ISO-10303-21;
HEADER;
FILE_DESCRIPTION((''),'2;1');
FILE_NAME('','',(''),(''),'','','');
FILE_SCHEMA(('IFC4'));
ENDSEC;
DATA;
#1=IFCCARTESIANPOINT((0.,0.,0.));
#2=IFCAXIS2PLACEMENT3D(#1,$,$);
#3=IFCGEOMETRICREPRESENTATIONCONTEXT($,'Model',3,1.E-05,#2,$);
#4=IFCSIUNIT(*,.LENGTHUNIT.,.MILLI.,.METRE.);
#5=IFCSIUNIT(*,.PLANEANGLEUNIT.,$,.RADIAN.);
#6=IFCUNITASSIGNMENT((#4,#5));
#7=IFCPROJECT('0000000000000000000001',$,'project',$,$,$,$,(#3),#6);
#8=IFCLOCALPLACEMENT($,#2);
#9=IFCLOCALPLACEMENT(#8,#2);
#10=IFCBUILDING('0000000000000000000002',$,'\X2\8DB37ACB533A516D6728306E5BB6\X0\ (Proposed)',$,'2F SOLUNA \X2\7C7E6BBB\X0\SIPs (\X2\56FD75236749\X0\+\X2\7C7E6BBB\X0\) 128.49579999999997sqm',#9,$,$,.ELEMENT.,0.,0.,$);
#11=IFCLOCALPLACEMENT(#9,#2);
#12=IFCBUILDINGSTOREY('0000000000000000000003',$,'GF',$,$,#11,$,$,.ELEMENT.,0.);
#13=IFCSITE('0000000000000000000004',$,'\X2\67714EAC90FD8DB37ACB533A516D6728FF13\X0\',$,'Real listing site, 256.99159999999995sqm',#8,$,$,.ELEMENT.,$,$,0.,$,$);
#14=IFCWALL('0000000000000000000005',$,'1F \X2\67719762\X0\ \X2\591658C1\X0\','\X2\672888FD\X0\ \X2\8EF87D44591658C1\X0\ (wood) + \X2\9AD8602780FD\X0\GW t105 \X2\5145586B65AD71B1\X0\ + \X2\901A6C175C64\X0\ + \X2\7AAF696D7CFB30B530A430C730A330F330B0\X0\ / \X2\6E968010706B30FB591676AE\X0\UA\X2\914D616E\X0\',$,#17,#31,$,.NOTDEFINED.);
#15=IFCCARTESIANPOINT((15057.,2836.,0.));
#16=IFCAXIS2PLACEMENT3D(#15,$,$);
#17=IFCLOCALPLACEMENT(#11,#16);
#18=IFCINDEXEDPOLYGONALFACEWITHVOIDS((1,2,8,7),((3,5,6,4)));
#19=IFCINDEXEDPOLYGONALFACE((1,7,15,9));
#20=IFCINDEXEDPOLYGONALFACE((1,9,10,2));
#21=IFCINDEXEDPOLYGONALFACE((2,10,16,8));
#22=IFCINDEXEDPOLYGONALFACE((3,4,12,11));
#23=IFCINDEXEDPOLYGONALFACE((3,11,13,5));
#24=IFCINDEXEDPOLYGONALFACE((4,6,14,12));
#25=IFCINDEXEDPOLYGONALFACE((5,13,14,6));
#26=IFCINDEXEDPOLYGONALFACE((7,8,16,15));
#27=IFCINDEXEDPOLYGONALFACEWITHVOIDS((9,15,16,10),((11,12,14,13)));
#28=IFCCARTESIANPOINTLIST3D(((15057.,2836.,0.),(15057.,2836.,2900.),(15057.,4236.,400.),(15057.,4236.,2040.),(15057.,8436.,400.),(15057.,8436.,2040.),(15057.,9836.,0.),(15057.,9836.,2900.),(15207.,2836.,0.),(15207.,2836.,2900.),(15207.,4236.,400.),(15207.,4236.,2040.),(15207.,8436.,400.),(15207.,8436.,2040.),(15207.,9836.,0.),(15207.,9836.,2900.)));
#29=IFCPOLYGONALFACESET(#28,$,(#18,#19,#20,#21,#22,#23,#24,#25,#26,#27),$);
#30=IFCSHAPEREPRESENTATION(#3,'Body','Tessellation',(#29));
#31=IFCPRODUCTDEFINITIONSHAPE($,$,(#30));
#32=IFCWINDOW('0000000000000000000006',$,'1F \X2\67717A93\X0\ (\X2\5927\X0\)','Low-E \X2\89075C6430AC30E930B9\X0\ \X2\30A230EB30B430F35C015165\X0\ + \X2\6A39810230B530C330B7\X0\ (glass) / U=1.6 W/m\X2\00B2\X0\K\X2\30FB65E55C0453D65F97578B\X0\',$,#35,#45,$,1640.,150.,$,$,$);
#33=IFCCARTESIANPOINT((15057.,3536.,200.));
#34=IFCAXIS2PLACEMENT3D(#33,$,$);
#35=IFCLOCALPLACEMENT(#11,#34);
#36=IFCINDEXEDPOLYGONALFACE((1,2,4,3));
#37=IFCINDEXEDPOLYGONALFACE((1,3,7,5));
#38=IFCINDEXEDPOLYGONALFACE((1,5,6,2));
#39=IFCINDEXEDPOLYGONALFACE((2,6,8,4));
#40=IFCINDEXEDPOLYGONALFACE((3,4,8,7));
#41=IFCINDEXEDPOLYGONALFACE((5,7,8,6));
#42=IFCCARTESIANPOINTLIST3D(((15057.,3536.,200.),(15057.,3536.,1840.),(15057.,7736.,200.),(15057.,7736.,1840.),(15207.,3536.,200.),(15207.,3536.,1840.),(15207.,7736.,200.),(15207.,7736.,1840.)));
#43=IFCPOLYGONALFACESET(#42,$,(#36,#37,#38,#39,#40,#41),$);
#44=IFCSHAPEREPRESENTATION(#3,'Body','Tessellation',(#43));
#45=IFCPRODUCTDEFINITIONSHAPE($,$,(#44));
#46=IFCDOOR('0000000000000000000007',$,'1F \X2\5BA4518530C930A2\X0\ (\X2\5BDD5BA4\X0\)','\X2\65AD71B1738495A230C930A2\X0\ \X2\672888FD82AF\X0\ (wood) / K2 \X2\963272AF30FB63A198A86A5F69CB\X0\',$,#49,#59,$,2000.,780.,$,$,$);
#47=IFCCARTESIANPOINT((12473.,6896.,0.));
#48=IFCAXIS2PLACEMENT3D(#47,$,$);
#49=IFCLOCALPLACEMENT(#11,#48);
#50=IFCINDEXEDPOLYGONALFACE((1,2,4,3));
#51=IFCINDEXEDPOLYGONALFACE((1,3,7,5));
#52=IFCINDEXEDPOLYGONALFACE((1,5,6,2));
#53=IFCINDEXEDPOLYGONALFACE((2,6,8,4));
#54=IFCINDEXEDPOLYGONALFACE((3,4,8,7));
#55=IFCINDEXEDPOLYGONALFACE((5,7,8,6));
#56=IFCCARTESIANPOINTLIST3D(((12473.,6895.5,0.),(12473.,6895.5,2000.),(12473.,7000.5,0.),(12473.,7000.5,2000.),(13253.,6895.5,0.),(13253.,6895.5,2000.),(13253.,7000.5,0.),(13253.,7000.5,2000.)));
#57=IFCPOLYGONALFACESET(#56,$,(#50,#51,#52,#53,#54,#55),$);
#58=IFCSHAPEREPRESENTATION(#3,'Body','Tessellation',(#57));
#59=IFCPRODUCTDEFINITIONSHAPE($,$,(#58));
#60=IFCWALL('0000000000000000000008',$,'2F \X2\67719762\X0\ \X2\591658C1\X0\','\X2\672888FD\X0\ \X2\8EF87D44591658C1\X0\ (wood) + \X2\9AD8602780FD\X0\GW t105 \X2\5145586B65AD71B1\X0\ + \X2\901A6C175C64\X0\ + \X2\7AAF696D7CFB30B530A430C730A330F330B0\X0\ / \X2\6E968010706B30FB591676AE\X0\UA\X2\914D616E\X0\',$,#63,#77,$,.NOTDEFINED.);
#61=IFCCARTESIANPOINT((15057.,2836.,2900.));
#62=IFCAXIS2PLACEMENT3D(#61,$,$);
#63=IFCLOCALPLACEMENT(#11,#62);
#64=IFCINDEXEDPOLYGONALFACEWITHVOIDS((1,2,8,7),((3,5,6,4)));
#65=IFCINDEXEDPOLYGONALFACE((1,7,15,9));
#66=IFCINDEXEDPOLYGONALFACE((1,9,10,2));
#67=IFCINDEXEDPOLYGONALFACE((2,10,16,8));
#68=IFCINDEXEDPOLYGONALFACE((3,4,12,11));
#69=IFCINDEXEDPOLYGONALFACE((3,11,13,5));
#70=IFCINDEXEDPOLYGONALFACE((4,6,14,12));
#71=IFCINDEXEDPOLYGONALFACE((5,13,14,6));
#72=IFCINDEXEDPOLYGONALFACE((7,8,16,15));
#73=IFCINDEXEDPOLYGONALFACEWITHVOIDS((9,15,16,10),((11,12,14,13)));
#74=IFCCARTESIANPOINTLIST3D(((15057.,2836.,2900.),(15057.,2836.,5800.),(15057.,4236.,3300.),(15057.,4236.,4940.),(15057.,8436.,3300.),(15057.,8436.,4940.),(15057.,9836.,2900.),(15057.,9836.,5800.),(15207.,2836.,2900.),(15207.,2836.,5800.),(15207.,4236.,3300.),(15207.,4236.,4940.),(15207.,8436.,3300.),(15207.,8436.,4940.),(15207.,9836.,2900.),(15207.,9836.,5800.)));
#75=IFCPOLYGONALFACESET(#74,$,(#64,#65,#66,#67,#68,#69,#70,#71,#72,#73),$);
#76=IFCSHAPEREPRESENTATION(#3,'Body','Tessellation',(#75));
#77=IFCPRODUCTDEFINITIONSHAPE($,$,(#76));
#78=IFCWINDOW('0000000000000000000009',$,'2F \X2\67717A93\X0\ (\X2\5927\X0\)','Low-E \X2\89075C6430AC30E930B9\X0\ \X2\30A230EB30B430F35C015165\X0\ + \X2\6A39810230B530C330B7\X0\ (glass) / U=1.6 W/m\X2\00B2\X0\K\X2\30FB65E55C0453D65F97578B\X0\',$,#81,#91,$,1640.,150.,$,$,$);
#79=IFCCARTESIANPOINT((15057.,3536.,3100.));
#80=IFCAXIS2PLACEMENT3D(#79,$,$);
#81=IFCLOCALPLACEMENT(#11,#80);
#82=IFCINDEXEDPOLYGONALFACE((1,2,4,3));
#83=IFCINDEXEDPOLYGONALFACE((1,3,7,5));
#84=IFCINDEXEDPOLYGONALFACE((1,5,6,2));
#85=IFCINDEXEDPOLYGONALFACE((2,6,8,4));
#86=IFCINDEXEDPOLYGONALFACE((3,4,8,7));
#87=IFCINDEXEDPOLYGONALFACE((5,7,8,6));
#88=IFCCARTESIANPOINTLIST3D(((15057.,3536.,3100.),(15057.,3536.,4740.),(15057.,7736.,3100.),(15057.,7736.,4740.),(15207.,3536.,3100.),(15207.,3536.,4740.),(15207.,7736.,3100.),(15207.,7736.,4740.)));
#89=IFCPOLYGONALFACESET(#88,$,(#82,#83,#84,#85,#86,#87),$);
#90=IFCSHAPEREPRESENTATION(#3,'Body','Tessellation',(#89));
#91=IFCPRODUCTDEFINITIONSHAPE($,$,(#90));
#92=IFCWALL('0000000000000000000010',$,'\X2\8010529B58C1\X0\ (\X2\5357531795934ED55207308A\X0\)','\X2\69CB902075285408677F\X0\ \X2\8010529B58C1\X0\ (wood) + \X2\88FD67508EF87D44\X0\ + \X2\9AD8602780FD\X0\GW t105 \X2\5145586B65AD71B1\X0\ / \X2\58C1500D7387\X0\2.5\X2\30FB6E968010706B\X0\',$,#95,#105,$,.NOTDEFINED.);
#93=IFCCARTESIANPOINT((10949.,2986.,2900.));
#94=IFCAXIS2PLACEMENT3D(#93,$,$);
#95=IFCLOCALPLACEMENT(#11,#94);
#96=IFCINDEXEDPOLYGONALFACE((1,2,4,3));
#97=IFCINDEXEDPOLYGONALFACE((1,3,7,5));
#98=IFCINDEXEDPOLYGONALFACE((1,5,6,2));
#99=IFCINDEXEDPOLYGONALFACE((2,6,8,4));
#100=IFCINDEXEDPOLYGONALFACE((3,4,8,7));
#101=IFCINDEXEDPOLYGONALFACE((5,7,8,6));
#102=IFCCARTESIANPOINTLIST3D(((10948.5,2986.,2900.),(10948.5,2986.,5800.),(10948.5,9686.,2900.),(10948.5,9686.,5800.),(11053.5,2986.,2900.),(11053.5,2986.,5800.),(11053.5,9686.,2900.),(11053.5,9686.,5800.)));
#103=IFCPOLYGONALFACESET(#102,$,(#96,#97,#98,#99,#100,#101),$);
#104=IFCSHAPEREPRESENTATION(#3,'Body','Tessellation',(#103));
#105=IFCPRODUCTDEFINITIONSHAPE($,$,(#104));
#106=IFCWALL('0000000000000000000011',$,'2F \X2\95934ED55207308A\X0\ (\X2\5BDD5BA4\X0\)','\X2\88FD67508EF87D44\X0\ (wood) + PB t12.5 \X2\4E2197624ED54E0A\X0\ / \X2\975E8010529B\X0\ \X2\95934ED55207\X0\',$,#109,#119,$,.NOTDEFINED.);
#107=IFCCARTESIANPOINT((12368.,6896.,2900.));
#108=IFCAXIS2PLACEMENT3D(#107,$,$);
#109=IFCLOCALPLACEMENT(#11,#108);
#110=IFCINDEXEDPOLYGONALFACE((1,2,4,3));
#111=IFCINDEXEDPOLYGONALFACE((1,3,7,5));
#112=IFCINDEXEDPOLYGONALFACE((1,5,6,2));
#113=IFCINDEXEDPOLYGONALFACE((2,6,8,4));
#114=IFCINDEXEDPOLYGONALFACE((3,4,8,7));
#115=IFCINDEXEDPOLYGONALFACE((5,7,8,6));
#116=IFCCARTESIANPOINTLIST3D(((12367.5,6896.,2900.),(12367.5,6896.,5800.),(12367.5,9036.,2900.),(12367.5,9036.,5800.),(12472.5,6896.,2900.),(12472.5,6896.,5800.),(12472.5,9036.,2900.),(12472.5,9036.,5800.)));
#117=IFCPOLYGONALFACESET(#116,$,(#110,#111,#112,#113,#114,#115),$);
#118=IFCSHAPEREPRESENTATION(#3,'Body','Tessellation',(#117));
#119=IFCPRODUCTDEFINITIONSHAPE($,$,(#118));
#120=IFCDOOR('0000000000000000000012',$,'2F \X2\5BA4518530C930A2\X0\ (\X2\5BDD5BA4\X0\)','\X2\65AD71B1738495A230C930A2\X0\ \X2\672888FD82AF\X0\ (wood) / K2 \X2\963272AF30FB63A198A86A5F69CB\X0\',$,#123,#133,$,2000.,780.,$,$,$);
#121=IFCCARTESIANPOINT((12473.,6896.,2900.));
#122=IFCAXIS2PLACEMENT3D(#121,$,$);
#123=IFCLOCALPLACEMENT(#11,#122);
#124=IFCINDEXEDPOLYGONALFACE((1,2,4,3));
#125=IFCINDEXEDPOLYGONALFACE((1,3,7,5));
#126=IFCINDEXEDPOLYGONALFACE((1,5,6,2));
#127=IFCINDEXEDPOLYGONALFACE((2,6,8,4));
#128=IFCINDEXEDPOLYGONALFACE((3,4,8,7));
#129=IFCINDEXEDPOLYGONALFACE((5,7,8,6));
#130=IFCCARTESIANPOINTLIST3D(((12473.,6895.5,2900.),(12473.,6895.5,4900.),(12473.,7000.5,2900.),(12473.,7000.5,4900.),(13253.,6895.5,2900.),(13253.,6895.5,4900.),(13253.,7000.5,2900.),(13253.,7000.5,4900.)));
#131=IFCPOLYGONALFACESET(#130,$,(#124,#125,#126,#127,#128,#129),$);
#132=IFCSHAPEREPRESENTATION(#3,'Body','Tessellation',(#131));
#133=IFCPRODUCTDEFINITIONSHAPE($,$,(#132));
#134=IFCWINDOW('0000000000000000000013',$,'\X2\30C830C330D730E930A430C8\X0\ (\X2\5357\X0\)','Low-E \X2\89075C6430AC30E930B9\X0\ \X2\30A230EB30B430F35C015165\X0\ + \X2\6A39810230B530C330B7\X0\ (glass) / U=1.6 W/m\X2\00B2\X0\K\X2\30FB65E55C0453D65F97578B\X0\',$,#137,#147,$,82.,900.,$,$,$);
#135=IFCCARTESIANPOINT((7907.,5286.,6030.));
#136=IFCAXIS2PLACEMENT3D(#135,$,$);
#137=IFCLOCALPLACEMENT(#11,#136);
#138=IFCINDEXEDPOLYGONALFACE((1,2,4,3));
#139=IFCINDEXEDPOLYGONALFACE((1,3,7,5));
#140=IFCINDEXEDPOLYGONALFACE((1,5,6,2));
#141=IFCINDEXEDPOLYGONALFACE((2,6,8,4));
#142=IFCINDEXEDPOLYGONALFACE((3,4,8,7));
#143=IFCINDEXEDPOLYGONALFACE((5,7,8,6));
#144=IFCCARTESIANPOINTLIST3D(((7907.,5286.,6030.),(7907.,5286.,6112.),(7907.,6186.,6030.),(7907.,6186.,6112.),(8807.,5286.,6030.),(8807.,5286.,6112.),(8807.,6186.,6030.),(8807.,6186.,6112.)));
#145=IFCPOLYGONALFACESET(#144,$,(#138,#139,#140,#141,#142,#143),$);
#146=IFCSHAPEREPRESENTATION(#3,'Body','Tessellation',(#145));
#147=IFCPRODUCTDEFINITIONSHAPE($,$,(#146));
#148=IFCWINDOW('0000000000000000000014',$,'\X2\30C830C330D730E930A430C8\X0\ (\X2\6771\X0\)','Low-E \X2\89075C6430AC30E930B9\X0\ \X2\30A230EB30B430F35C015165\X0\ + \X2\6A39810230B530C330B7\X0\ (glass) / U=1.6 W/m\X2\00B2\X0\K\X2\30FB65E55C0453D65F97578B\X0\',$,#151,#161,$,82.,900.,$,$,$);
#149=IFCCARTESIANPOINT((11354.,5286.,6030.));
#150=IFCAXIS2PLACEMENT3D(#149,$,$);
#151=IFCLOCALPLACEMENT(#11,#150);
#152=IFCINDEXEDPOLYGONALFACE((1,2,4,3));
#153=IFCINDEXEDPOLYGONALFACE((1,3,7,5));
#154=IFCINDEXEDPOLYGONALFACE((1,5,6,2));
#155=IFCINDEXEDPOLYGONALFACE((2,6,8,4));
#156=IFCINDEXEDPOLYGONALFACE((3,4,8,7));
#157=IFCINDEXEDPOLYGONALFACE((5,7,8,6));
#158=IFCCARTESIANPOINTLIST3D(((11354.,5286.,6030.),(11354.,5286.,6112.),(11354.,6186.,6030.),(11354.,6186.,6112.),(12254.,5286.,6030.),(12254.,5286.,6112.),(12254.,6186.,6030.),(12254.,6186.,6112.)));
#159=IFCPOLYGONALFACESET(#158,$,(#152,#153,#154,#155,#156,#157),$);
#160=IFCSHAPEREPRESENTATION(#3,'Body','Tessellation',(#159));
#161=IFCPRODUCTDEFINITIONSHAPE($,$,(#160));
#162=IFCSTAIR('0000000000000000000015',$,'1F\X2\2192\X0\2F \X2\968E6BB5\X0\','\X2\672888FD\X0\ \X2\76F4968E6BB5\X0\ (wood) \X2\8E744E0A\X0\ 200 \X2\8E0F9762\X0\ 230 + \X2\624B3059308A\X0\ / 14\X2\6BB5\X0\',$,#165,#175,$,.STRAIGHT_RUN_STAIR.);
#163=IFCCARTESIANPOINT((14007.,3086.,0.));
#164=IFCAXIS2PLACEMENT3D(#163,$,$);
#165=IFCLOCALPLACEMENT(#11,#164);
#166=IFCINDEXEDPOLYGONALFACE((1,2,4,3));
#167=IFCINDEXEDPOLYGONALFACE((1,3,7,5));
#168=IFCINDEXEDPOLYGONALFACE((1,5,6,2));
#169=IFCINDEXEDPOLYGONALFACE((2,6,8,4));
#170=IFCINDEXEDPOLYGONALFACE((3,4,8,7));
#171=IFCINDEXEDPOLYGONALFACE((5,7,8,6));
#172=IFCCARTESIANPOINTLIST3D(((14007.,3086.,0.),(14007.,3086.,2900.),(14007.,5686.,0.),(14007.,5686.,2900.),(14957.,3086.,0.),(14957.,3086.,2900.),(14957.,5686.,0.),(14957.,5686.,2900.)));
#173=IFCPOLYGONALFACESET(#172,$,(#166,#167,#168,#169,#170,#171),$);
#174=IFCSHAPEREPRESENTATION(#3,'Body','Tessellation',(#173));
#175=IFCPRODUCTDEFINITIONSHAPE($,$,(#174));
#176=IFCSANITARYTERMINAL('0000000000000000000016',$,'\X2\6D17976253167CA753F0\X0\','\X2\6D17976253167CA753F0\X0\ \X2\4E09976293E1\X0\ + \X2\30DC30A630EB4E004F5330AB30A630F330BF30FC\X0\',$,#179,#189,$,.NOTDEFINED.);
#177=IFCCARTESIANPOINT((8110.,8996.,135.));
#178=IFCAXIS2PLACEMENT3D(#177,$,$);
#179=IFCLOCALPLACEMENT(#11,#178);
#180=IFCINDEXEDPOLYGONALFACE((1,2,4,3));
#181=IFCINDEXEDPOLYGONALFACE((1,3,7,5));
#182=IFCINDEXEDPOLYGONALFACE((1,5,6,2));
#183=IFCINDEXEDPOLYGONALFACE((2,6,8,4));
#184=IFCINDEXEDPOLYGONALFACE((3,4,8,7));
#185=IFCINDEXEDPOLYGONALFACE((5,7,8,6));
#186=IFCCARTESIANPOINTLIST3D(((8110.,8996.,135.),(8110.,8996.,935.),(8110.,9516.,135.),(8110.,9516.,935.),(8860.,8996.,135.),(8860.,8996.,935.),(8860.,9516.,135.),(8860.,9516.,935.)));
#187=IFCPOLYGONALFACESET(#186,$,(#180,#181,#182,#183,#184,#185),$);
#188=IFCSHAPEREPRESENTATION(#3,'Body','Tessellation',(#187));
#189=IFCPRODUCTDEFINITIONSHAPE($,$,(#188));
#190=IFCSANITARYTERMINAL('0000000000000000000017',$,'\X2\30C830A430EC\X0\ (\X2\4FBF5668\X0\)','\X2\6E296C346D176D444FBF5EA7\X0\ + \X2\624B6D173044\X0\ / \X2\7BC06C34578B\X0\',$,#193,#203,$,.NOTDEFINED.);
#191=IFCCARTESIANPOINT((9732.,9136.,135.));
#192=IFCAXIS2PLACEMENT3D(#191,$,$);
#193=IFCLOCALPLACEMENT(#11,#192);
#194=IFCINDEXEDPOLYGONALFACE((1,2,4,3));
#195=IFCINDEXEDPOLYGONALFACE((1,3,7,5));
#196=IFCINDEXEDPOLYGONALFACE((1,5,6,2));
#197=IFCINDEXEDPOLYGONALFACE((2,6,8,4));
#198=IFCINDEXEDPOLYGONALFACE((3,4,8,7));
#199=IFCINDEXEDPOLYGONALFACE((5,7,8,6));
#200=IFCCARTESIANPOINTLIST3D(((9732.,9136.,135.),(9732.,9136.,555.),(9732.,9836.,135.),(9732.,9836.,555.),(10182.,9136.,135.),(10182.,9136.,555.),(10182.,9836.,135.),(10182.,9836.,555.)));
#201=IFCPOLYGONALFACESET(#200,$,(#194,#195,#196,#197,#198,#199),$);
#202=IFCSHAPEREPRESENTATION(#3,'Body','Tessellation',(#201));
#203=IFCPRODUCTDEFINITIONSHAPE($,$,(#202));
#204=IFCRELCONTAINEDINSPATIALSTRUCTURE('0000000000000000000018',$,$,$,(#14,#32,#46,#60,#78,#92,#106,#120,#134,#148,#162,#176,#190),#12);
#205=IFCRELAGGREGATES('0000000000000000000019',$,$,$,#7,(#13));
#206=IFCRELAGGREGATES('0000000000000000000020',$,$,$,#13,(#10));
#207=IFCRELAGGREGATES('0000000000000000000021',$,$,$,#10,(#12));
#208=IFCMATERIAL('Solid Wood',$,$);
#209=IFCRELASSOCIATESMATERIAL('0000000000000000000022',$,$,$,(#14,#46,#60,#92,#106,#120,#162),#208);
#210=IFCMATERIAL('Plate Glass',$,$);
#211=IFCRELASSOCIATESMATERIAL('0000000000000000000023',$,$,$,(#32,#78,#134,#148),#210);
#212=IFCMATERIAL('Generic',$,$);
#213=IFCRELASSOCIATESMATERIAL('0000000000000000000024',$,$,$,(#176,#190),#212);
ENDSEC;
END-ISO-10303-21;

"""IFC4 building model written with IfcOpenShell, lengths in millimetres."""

from ifc_helpers import new_model, si_unit, frame, frame_2d, origin, place, context, project, spatial, rectangle, extrude, material, element, fill, save


model = new_model("IFC4")

# Units and contexts
model_context = context("Model", 3, precision=1e-05, world=origin())
ifc_project = project(units=[si_unit("LENGTHUNIT", "METRE", prefix="MILLI"), si_unit("PLANEANGLEUNIT", "RADIAN")], contexts=[model_context])

# Site, building, storey
site_placement = place(None, origin())
site = spatial("IfcSite", under=ifc_project, at=site_placement, Name="東京都足立区六木３", ObjectType="Real listing site, 256.99159999999995sqm", CompositionType="ELEMENT", RefElevation=0.0)
building_placement = place(site_placement, origin())
building = spatial("IfcBuilding", under=site, at=building_placement, Name="足立区六木の家 (Proposed)", ObjectType="2F SOLUNA 籾殻SIPs (国産杉+籾殻) 128.49579999999997sqm", CompositionType="ELEMENT", ElevationOfRefHeight=0.0, ElevationOfTerrain=0.0)
storey_placement = place(building_placement, origin())
storey = spatial("IfcBuildingStorey", under=building, at=storey_placement, Name="GF", CompositionType="ELEMENT", Elevation=0.0)

# Wall, opening, window
ifc_material_1 = material(Name="Solid Wood")
wall_1_placement = place(storey_placement, frame((15057.0, 2836.0, 0.0)))
wall_1 = element("IfcWall", 1, at=wall_1_placement, inside=storey, material=ifc_material_1, Name="1F 東面 外壁", Description="木製 軸組外壁 (wood) + 高性能GW t105 充填断熱 + 通気層 + 窯業系サイディング / 準耐火・外皮UA配慮", PredefinedType="NOTDEFINED", context=model_context, shape_type="SweptSolid", body=[
    extrude(rectangle(XDim=150.0, YDim=7000.0, at=frame_2d((75.0, 3500.0))), frame((15057.0, 2836.0, 0.0)), (0.0, 0.0, 1.0), 2900.0),
])
opening_1_placement = place(storey_placement, frame((15057.0, 3536.0, 200.0)))
opening_1 = element("IfcOpeningElement", 2, at=opening_1_placement, cuts=wall_1, PredefinedType="NOTDEFINED", context=model_context, shape_type="SweptSolid", body=[
    extrude(rectangle(XDim=150.0, YDim=4200.0, at=frame_2d((75.0, 2100.0))), frame((15057.0, 3536.0, 200.0)), (0.0, 0.0, 1.0), 1640.0),
])
ifc_material_2 = material(Name="Plate Glass")
window_1_placement = place(storey_placement, frame((15057.0, 3536.0, 200.0)))
window_1 = element("IfcWindow", 3, at=window_1_placement, inside=storey, material=ifc_material_2, Name="1F 東窓 (大)", Description="Low-E 複層ガラス アルゴン封入 + 樹脂サッシ (glass) / U=1.6 W/m²K・日射取得型", OverallHeight=1640.0, OverallWidth=150.0, context=model_context, shape_type="SweptSolid", body=[
    extrude(rectangle(XDim=150.0, YDim=4200.0, at=frame_2d((75.0, 2100.0))), frame((15057.0, 3536.0, 200.0)), (0.0, 0.0, 1.0), 1640.0),
])
fill(opening_1, window_1)

# Door
door_1_placement = place(storey_placement, frame((12473.0, 6896.0, 0.0)))
element("IfcDoor", 4, at=door_1_placement, inside=storey, material=ifc_material_1, Name="1F 室内ドア (寝室)", Description="断熱玄関ドア 木製芯 (wood) / K2 防犯・採風機構", OverallHeight=2000.0, OverallWidth=780.0, context=model_context, shape_type="SweptSolid", body=[
    extrude(rectangle(XDim=780.0, YDim=105.0, at=frame_2d((390.0, 52.0))), frame((12473.0, 6896.0, 0.0)), (0.0, 0.0, 1.0), 2000.0),
])

# Wall, opening, window
wall_2_placement = place(storey_placement, frame((15057.0, 2836.0, 2900.0)))
wall_2 = element("IfcWall", 5, at=wall_2_placement, inside=storey, material=ifc_material_1, Name="2F 東面 外壁", Description="木製 軸組外壁 (wood) + 高性能GW t105 充填断熱 + 通気層 + 窯業系サイディング / 準耐火・外皮UA配慮", PredefinedType="NOTDEFINED", context=model_context, shape_type="SweptSolid", body=[
    extrude(rectangle(XDim=150.0, YDim=7000.0, at=frame_2d((75.0, 3500.0))), frame((15057.0, 2836.0, 2900.0)), (0.0, 0.0, 1.0), 2900.0),
])
opening_2_placement = place(storey_placement, frame((15057.0, 3536.0, 3100.0)))
opening_2 = element("IfcOpeningElement", 6, at=opening_2_placement, cuts=wall_2, PredefinedType="NOTDEFINED", context=model_context, shape_type="SweptSolid", body=[
    extrude(rectangle(XDim=150.0, YDim=4200.0, at=frame_2d((75.0, 2100.0))), frame((15057.0, 3536.0, 3100.0)), (0.0, 0.0, 1.0), 1640.0),
])
window_2_placement = place(storey_placement, frame((15057.0, 3536.0, 3100.0)))
window_2 = element("IfcWindow", 7, at=window_2_placement, inside=storey, material=ifc_material_2, Name="2F 東窓 (大)", Description="Low-E 複層ガラス アルゴン封入 + 樹脂サッシ (glass) / U=1.6 W/m²K・日射取得型", OverallHeight=1640.0, OverallWidth=150.0, context=model_context, shape_type="SweptSolid", body=[
    extrude(rectangle(XDim=150.0, YDim=4200.0, at=frame_2d((75.0, 2100.0))), frame((15057.0, 3536.0, 3100.0)), (0.0, 0.0, 1.0), 1640.0),
])
fill(opening_2, window_2)

# Walls
wall_3_placement = place(storey_placement, frame((10949.0, 2986.0, 2900.0)))
element("IfcWall", 8, at=wall_3_placement, inside=storey, material=ifc_material_1, Name="耐力壁 (南北間仕切り)", Description="構造用合板 耐力壁 (wood) + 製材軸組 + 高性能GW t105 充填断熱 / 壁倍率2.5・準耐火", PredefinedType="NOTDEFINED", context=model_context, shape_type="SweptSolid", body=[
    extrude(rectangle(XDim=105.0, YDim=6700.0, at=frame_2d((52.0, 3350.0))), frame((10949.0, 2986.0, 2900.0)), (0.0, 0.0, 1.0), 2900.0),
])
wall_4_placement = place(storey_placement, frame((12368.0, 6896.0, 2900.0)))
element("IfcWall", 9, at=wall_4_placement, inside=storey, material=ifc_material_1, Name="2F 間仕切り (寝室)", Description="製材軸組 (wood) + PB t12.5 両面仕上 / 非耐力 間仕切", PredefinedType="NOTDEFINED", context=model_context, shape_type="SweptSolid", body=[
    extrude(rectangle(XDim=105.0, YDim=2140.0, at=frame_2d((52.0, 1070.0))), frame((12368.0, 6896.0, 2900.0)), (0.0, 0.0, 1.0), 2900.0),
])

# Door
door_2_placement = place(storey_placement, frame((12473.0, 6896.0, 2900.0)))
element("IfcDoor", 10, at=door_2_placement, inside=storey, material=ifc_material_1, Name="2F 室内ドア (寝室)", Description="断熱玄関ドア 木製芯 (wood) / K2 防犯・採風機構", OverallHeight=2000.0, OverallWidth=780.0, context=model_context, shape_type="SweptSolid", body=[
    extrude(rectangle(XDim=780.0, YDim=105.0, at=frame_2d((390.0, 52.0))), frame((12473.0, 6896.0, 2900.0)), (0.0, 0.0, 1.0), 2000.0),
])

# Windows
window_3_placement = place(storey_placement, frame((7907.0, 5286.0, 6030.0)))
element("IfcWindow", 11, at=window_3_placement, inside=storey, material=ifc_material_2, Name="トップライト (南)", Description="Low-E 複層ガラス アルゴン封入 + 樹脂サッシ (glass) / U=1.6 W/m²K・日射取得型", OverallHeight=82.0, OverallWidth=900.0, context=model_context, shape_type="SweptSolid", body=[
    extrude(rectangle(XDim=900.0, YDim=900.0, at=frame_2d((450.0, 450.0))), frame((7907.0, 5286.0, 6030.0)), (0.0, 0.0, 1.0), 82.0),
])
window_4_placement = place(storey_placement, frame((11354.0, 5286.0, 6030.0)))
element("IfcWindow", 12, at=window_4_placement, inside=storey, material=ifc_material_2, Name="トップライト (東)", Description="Low-E 複層ガラス アルゴン封入 + 樹脂サッシ (glass) / U=1.6 W/m²K・日射取得型", OverallHeight=82.0, OverallWidth=900.0, context=model_context, shape_type="SweptSolid", body=[
    extrude(rectangle(XDim=900.0, YDim=900.0, at=frame_2d((450.0, 450.0))), frame((11354.0, 5286.0, 6030.0)), (0.0, 0.0, 1.0), 82.0),
])

# Stair
stair_placement = place(storey_placement, frame((14007.0, 3086.0, 0.0)))
element("IfcStair", 13, at=stair_placement, inside=storey, material=ifc_material_1, Name="1F→2F 階段", Description="木製 直階段 (wood) 蹴上 200 踏面 230 + 手すり / 14段", PredefinedType="STRAIGHT_RUN_STAIR", context=model_context, shape_type="SweptSolid", body=[
    extrude(rectangle(XDim=950.0, YDim=2600.0, at=frame_2d((475.0, 1300.0))), frame((14007.0, 3086.0, 0.0)), (0.0, 0.0, 1.0), 2900.0),
])

# Sanitary terminals
ifc_material_3 = material(Name="Generic")
sanitary_terminal_1_placement = place(storey_placement, frame((8110.0, 8996.0, 135.0)))
element("IfcSanitaryTerminal", 14, at=sanitary_terminal_1_placement, inside=storey, material=ifc_material_3, Name="洗面化粧台", Description="洗面化粧台 三面鏡 + ボウル一体カウンター", PredefinedType="NOTDEFINED", context=model_context, shape_type="SweptSolid", body=[
    extrude(rectangle(XDim=750.0, YDim=520.0, at=frame_2d((375.0, 260.0))), frame((8110.0, 8996.0, 135.0)), (0.0, 0.0, 1.0), 800.0),
])
sanitary_terminal_2_placement = place(storey_placement, frame((9732.0, 9136.0, 135.0)))
element("IfcSanitaryTerminal", 15, at=sanitary_terminal_2_placement, inside=storey, material=ifc_material_3, Name="トイレ (便器)", Description="温水洗浄便座 + 手洗い / 節水型", PredefinedType="NOTDEFINED", context=model_context, shape_type="SweptSolid", body=[
    extrude(rectangle(XDim=450.0, YDim=700.0, at=frame_2d((225.0, 350.0))), frame((9732.0, 9136.0, 135.0)), (0.0, 0.0, 1.0), 420.0),
])

save(model, "model.ifc")
